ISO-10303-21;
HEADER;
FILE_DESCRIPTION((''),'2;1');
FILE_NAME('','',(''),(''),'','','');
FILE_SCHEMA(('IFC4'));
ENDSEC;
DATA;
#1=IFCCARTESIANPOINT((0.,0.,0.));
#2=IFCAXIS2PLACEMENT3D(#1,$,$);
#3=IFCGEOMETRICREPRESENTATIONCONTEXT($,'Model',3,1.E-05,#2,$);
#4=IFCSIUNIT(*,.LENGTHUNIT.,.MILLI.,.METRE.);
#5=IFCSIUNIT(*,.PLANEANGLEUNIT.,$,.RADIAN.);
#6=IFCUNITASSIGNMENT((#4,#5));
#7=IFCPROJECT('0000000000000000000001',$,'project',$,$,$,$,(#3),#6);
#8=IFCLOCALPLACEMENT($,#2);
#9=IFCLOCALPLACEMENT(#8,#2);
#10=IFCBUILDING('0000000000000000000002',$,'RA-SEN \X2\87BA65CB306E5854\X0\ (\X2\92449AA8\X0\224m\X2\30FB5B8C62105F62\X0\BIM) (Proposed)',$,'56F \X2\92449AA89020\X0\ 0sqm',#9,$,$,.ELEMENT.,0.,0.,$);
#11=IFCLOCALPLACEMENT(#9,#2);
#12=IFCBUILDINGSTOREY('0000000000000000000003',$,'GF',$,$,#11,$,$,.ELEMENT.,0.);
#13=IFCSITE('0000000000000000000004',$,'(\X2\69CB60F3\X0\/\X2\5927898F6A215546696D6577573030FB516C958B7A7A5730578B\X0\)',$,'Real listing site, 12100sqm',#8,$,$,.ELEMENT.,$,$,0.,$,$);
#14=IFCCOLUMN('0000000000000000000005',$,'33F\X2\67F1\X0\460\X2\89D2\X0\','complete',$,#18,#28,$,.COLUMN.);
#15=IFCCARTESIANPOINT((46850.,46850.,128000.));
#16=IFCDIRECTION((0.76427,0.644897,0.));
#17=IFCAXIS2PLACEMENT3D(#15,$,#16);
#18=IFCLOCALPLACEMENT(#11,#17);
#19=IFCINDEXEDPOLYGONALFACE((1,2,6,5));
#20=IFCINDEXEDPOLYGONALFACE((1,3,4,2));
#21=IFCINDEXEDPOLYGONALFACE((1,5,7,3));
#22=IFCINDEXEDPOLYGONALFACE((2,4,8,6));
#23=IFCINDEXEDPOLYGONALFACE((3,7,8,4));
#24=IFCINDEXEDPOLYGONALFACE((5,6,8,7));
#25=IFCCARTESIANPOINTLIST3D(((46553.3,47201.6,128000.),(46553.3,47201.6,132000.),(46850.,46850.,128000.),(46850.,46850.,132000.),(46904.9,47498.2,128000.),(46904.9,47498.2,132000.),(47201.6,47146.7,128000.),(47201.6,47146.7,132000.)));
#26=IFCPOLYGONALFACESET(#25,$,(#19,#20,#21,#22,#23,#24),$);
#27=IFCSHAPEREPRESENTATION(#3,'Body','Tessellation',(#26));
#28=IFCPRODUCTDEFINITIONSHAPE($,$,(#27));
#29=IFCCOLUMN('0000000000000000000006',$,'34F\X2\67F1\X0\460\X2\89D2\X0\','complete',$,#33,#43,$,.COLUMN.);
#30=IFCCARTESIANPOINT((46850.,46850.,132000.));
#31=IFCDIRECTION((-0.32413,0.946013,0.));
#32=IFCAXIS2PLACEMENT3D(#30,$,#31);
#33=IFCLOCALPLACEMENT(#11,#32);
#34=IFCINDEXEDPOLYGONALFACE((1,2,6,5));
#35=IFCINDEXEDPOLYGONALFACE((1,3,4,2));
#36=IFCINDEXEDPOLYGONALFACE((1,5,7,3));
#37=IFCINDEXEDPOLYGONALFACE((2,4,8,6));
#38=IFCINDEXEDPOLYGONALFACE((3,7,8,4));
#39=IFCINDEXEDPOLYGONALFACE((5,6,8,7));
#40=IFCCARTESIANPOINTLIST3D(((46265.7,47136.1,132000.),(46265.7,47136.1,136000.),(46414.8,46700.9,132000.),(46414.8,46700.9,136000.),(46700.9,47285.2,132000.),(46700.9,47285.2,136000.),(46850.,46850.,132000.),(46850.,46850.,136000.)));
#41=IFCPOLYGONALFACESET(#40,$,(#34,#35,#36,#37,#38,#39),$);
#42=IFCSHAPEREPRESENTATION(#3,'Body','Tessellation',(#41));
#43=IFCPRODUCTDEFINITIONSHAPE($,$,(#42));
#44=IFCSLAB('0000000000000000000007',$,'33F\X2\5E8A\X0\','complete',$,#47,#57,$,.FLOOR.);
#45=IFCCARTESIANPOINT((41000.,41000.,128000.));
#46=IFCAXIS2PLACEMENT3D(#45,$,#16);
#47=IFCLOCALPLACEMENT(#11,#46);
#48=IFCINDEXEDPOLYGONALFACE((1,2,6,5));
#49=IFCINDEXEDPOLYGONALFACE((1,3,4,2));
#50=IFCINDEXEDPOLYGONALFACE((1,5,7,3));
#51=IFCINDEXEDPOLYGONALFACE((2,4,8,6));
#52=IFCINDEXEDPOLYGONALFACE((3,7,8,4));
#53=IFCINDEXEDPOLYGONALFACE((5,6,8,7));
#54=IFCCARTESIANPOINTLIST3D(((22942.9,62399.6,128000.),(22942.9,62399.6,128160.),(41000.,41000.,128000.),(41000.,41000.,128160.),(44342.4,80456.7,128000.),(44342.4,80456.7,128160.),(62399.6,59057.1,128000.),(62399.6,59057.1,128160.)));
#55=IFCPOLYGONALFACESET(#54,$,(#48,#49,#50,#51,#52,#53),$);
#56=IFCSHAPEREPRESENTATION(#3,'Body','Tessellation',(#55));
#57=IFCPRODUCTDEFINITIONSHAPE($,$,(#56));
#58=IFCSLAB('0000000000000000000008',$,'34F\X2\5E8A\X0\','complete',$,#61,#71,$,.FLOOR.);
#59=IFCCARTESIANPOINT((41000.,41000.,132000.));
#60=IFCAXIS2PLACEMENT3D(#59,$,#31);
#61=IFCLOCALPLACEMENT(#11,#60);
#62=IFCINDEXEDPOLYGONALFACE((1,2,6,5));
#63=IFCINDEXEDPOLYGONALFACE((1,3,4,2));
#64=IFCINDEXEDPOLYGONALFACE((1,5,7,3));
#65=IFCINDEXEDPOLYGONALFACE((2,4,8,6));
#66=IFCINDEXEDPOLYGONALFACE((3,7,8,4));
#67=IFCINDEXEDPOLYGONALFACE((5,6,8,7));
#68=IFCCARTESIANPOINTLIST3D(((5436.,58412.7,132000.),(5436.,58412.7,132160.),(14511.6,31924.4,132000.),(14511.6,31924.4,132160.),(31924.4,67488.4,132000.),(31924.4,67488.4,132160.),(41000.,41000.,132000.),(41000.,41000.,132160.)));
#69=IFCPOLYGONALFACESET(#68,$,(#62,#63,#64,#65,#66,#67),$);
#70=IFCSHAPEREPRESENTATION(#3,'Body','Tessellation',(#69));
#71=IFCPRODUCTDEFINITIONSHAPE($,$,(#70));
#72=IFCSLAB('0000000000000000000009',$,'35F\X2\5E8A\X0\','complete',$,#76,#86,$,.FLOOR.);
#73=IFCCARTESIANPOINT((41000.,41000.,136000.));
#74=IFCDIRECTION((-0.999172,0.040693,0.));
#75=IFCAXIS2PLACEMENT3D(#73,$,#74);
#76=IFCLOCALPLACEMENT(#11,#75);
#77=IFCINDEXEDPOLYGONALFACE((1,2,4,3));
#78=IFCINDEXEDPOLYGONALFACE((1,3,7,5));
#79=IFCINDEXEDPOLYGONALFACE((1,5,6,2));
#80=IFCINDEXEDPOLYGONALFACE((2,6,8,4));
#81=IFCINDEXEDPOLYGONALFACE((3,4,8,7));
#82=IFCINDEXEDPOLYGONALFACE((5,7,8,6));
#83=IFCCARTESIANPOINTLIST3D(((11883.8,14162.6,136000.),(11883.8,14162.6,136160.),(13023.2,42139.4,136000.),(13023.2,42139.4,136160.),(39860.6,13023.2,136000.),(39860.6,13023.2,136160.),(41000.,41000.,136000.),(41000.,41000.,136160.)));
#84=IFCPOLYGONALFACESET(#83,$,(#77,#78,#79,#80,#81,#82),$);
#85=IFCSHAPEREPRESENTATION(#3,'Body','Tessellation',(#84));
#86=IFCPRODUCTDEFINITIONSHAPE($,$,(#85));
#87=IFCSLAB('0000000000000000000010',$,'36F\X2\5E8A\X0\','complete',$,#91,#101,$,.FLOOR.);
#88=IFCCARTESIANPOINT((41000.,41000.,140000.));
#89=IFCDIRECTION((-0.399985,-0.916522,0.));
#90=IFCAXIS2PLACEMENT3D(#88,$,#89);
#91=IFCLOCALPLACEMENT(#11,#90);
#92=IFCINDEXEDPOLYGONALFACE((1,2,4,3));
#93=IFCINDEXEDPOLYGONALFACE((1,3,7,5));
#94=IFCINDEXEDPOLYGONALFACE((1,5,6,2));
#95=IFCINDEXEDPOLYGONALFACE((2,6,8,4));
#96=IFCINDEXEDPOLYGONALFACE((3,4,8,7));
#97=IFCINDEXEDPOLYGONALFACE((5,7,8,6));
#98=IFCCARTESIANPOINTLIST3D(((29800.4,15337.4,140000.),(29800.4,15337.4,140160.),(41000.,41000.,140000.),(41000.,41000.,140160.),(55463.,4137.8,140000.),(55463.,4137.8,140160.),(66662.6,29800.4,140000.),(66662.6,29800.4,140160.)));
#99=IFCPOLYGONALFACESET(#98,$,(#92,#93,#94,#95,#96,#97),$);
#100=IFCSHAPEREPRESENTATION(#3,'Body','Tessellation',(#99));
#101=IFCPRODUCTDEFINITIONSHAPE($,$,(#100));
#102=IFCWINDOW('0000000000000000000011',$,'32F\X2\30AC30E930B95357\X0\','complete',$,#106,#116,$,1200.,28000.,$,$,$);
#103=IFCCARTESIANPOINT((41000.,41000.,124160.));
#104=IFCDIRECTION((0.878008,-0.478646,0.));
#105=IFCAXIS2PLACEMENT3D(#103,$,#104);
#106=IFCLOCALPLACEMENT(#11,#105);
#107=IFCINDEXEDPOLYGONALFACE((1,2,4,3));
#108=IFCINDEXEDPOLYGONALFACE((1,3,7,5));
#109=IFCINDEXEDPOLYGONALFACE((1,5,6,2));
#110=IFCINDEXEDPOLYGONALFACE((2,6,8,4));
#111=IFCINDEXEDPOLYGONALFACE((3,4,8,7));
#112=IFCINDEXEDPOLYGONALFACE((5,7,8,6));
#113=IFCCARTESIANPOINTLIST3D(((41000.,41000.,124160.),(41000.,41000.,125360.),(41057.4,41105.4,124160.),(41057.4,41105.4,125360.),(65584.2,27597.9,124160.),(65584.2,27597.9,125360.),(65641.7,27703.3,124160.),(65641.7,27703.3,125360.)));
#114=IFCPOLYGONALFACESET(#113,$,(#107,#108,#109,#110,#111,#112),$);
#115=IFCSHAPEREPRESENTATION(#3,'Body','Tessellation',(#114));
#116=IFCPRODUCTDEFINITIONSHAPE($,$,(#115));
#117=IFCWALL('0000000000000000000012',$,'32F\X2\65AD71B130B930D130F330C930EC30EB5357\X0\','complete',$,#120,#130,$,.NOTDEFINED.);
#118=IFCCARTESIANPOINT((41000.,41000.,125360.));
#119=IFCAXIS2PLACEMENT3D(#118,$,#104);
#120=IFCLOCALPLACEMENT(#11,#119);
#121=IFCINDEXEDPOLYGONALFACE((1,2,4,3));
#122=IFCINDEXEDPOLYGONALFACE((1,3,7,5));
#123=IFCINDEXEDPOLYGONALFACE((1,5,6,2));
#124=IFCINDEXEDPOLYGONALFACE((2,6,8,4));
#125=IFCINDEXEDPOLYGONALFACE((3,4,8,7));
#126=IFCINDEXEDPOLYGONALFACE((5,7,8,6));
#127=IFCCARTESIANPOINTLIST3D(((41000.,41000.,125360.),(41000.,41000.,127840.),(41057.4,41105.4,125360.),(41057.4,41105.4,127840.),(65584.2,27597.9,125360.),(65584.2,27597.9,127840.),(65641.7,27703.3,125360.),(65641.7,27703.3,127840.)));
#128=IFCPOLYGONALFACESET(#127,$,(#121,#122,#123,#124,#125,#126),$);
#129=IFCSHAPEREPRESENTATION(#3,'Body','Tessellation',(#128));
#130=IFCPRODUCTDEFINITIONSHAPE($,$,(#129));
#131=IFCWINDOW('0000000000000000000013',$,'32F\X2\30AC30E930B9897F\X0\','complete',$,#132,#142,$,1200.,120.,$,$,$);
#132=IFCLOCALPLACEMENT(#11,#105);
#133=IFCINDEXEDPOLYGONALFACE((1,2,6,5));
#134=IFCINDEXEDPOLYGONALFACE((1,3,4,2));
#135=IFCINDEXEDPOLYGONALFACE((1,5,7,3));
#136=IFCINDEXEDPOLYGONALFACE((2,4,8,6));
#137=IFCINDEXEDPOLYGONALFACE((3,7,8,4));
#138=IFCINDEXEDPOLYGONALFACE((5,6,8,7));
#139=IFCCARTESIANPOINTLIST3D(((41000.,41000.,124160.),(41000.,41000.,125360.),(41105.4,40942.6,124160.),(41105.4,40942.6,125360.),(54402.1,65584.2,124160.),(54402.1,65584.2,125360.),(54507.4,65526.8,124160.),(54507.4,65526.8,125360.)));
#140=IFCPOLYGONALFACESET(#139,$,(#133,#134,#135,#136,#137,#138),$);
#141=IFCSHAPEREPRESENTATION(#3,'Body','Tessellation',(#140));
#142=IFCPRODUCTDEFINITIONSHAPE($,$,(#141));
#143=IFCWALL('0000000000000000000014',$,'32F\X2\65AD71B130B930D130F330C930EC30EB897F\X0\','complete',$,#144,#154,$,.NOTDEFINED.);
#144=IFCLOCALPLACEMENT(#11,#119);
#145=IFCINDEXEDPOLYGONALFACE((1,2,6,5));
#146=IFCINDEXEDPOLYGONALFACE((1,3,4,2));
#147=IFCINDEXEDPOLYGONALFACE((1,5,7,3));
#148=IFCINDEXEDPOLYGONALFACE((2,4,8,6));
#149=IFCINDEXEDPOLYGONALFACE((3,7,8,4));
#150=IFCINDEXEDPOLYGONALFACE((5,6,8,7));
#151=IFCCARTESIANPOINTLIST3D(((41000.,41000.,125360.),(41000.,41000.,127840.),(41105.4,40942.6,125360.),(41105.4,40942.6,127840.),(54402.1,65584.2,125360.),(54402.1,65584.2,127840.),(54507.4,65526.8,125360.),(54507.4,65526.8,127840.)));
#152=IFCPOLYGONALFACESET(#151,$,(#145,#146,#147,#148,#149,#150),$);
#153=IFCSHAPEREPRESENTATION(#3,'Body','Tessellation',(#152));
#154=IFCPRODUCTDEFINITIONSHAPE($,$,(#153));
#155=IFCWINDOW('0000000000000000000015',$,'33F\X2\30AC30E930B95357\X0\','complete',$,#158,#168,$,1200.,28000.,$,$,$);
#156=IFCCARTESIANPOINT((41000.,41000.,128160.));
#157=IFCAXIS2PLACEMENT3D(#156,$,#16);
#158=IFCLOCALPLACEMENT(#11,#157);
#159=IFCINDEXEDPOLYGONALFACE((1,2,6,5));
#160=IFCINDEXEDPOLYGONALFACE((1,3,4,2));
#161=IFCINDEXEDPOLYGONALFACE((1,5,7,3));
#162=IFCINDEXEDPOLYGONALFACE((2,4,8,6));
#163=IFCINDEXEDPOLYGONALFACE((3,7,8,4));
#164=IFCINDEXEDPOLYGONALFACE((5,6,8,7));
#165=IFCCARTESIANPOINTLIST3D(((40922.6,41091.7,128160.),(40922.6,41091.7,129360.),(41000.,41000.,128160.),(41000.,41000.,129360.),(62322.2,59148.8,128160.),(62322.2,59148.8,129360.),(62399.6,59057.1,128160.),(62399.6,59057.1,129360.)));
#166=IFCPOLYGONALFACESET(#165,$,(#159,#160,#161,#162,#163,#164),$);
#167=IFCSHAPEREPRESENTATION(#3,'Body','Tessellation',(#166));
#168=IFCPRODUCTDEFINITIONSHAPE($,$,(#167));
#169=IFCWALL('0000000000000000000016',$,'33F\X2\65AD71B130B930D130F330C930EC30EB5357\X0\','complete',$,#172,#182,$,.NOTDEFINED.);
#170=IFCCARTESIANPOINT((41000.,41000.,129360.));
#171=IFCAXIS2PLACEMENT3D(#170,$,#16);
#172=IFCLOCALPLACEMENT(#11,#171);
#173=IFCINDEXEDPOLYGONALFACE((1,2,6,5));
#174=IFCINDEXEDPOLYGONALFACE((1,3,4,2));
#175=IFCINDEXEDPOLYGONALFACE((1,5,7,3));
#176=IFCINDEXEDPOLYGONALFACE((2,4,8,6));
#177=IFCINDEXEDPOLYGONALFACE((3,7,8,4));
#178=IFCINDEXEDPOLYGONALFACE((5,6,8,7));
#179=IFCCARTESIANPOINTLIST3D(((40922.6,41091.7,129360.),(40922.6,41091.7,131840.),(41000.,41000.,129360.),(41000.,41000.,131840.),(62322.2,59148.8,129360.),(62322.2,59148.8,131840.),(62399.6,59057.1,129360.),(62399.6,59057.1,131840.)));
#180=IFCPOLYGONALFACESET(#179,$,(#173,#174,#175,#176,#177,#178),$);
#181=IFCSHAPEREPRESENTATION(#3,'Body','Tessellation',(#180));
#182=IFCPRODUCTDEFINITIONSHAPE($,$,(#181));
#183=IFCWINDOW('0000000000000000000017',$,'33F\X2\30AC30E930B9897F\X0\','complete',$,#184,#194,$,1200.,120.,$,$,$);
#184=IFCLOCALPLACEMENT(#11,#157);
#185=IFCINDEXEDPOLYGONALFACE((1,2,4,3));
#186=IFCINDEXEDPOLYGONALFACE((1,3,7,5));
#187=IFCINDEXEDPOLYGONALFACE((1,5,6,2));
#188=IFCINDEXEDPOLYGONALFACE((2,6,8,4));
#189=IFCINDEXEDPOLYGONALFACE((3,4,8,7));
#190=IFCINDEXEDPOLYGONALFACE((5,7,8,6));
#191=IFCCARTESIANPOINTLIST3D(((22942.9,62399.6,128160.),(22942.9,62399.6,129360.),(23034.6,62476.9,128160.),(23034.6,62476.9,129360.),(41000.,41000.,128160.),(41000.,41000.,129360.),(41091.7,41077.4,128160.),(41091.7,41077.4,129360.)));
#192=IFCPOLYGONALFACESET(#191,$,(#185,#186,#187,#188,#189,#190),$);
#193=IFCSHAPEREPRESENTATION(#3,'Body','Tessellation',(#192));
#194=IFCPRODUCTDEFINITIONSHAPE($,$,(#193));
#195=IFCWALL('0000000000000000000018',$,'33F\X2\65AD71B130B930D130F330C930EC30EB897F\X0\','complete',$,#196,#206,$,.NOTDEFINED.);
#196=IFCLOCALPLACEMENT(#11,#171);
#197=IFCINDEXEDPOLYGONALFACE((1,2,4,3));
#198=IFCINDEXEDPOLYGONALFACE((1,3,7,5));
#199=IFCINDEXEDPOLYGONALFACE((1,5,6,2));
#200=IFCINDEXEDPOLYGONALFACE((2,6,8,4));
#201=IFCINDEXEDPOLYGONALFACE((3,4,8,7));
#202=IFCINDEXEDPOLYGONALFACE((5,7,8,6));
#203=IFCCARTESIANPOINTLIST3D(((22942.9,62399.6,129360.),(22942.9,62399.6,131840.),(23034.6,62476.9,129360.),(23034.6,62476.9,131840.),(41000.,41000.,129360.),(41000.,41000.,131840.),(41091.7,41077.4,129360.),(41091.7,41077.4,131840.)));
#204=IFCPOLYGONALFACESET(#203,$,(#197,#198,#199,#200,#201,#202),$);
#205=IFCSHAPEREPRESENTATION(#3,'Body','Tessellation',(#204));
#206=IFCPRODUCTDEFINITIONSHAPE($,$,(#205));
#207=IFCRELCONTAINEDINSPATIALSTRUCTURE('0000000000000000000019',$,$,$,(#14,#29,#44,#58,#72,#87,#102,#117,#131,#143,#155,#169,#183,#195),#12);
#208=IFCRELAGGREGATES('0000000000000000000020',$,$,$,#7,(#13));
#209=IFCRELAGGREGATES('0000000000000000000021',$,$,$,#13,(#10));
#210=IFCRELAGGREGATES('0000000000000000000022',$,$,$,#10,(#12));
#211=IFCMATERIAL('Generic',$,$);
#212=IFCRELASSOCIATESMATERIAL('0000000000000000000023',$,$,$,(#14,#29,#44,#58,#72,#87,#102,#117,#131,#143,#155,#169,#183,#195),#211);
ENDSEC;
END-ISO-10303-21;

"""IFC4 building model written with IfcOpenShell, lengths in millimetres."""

from ifc_helpers import new_model, si_unit, frame, frame_2d, origin, place, context, project, spatial, rectangle, extrude, material, element, save


model = new_model("IFC4")

# Units and contexts
model_context = context("Model", 3, precision=1e-05, world=origin())
ifc_project = project(units=[si_unit("LENGTHUNIT", "METRE", prefix="MILLI"), si_unit("PLANEANGLEUNIT", "RADIAN")], contexts=[model_context])

# Site, building, storey
site_placement = place(None, origin())
site = spatial("IfcSite", under=ifc_project, at=site_placement, Name="(構想/大規模商業敷地・公開空地型)", ObjectType="Real listing site, 12100sqm", CompositionType="ELEMENT", RefElevation=0.0)
building_placement = place(site_placement, origin())
building = spatial("IfcBuilding", under=site, at=building_placement, Name="RA-SEN 螺旋の塔 (鉄骨224m・完成形BIM) (Proposed)", ObjectType="56F 鉄骨造 0sqm", CompositionType="ELEMENT", ElevationOfRefHeight=0.0, ElevationOfTerrain=0.0)
storey_placement = place(building_placement, origin())
storey = spatial("IfcBuildingStorey", under=building, at=storey_placement, Name="GF", CompositionType="ELEMENT", Elevation=0.0)

# Columns
ifc_material = material(Name="Generic")
column_1_placement = place(storey_placement, frame((46850.0, 46850.0, 128000.0), x_axis=(0.76427, 0.644897, 0.0)))
element("IfcColumn", 1, at=column_1_placement, inside=storey, material=ifc_material, Name="33F柱460角", Description="complete", PredefinedType="COLUMN", context=model_context, shape_type="SweptSolid", body=[
    extrude(rectangle(XDim=460.0, YDim=460.0, at=frame_2d((230.0, 230.0))), frame((46850.0, 46850.0, 128000.0), x_axis=(0.76427, 0.644897, 0.0)), (0.0, 0.0, 1.0), 4000.0),
])
column_2_placement = place(storey_placement, frame((46850.0, 46850.0, 132000.0), x_axis=(-0.32413, 0.946013, 0.0)))
element("IfcColumn", 2, at=column_2_placement, inside=storey, material=ifc_material, Name="34F柱460角", Description="complete", PredefinedType="COLUMN", context=model_context, shape_type="SweptSolid", body=[
    extrude(rectangle(XDim=460.0, YDim=460.0, at=frame_2d((230.0, 230.0))), frame((46850.0, 46850.0, 132000.0), x_axis=(-0.32413, 0.946013, 0.0)), (0.0, 0.0, 1.0), 4000.0),
])

# Slabs
slab_1_placement = place(storey_placement, frame((41000.0, 41000.0, 128000.0), x_axis=(0.76427, 0.644897, 0.0)))
element("IfcSlab", 3, at=slab_1_placement, inside=storey, material=ifc_material, Name="33F床", Description="complete", PredefinedType="FLOOR", context=model_context, shape_type="SweptSolid", body=[
    extrude(rectangle(XDim=28000.0, YDim=28000.0, at=frame_2d((14000.0, 14000.0))), frame((41000.0, 41000.0, 128000.0), x_axis=(0.76427, 0.644897, 0.0)), (0.0, 0.0, 1.0), 160.0),
])
slab_2_placement = place(storey_placement, frame((41000.0, 41000.0, 132000.0), x_axis=(-0.32413, 0.946013, 0.0)))
element("IfcSlab", 4, at=slab_2_placement, inside=storey, material=ifc_material, Name="34F床", Description="complete", PredefinedType="FLOOR", context=model_context, shape_type="SweptSolid", body=[
    extrude(rectangle(XDim=28000.0, YDim=28000.0, at=frame_2d((14000.0, 14000.0))), frame((41000.0, 41000.0, 132000.0), x_axis=(-0.32413, 0.946013, 0.0)), (0.0, 0.0, 1.0), 160.0),
])
slab_3_placement = place(storey_placement, frame((41000.0, 41000.0, 136000.0), x_axis=(-0.999172, 0.040693, 0.0)))
element("IfcSlab", 5, at=slab_3_placement, inside=storey, material=ifc_material, Name="35F床", Description="complete", PredefinedType="FLOOR", context=model_context, shape_type="SweptSolid", body=[
    extrude(rectangle(XDim=28000.0, YDim=28000.0, at=frame_2d((14000.0, 14000.0))), frame((41000.0, 41000.0, 136000.0), x_axis=(-0.999172, 0.040693, 0.0)), (0.0, 0.0, 1.0), 160.0),
])
slab_4_placement = place(storey_placement, frame((41000.0, 41000.0, 140000.0), x_axis=(-0.399985, -0.916522, 0.0)))
element("IfcSlab", 6, at=slab_4_placement, inside=storey, material=ifc_material, Name="36F床", Description="complete", PredefinedType="FLOOR", context=model_context, shape_type="SweptSolid", body=[
    extrude(rectangle(XDim=28000.0, YDim=28000.0, at=frame_2d((14000.0, 14000.0))), frame((41000.0, 41000.0, 140000.0), x_axis=(-0.399985, -0.916522, 0.0)), (0.0, 0.0, 1.0), 160.0),
])

# Window
window_1_placement = place(storey_placement, frame((41000.0, 41000.0, 124160.0), x_axis=(0.878008, -0.478646, 0.0)))
element("IfcWindow", 7, at=window_1_placement, inside=storey, material=ifc_material, Name="32Fガラス南", Description="complete", OverallHeight=1200.0, OverallWidth=28000.0, context=model_context, shape_type="SweptSolid", body=[
    extrude(rectangle(XDim=28000.0, YDim=120.0, at=frame_2d((14000.0, 60.0))), frame((41000.0, 41000.0, 124160.0), x_axis=(0.878008, -0.478646, 0.0)), (0.0, 0.0, 1.0), 1200.0),
])

# Wall
wall_1_placement = place(storey_placement, frame((41000.0, 41000.0, 125360.0), x_axis=(0.878008, -0.478646, 0.0)))
element("IfcWall", 8, at=wall_1_placement, inside=storey, material=ifc_material, Name="32F断熱スパンドレル南", Description="complete", PredefinedType="NOTDEFINED", context=model_context, shape_type="SweptSolid", body=[
    extrude(rectangle(XDim=28000.0, YDim=120.0, at=frame_2d((14000.0, 60.0))), frame((41000.0, 41000.0, 125360.0), x_axis=(0.878008, -0.478646, 0.0)), (0.0, 0.0, 1.0), 2480.0),
])

# Window
window_2_placement = place(storey_placement, frame((41000.0, 41000.0, 124160.0), x_axis=(0.878008, -0.478646, 0.0)))
element("IfcWindow", 9, at=window_2_placement, inside=storey, material=ifc_material, Name="32Fガラス西", Description="complete", OverallHeight=1200.0, OverallWidth=120.0, context=model_context, shape_type="SweptSolid", body=[
    extrude(rectangle(XDim=120.0, YDim=28000.0, at=frame_2d((60.0, 14000.0))), frame((41000.0, 41000.0, 124160.0), x_axis=(0.878008, -0.478646, 0.0)), (0.0, 0.0, 1.0), 1200.0),
])

# Wall
wall_2_placement = place(storey_placement, frame((41000.0, 41000.0, 125360.0), x_axis=(0.878008, -0.478646, 0.0)))
element("IfcWall", 10, at=wall_2_placement, inside=storey, material=ifc_material, Name="32F断熱スパンドレル西", Description="complete", PredefinedType="NOTDEFINED", context=model_context, shape_type="SweptSolid", body=[
    extrude(rectangle(XDim=120.0, YDim=28000.0, at=frame_2d((60.0, 14000.0))), frame((41000.0, 41000.0, 125360.0), x_axis=(0.878008, -0.478646, 0.0)), (0.0, 0.0, 1.0), 2480.0),
])

# Window
window_3_placement = place(storey_placement, frame((41000.0, 41000.0, 128160.0), x_axis=(0.76427, 0.644897, 0.0)))
element("IfcWindow", 11, at=window_3_placement, inside=storey, material=ifc_material, Name="33Fガラス南", Description="complete", OverallHeight=1200.0, OverallWidth=28000.0, context=model_context, shape_type="SweptSolid", body=[
    extrude(rectangle(XDim=28000.0, YDim=120.0, at=frame_2d((14000.0, 60.0))), frame((41000.0, 41000.0, 128160.0), x_axis=(0.76427, 0.644897, 0.0)), (0.0, 0.0, 1.0), 1200.0),
])

# Wall
wall_3_placement = place(storey_placement, frame((41000.0, 41000.0, 129360.0), x_axis=(0.76427, 0.644897, 0.0)))
element("IfcWall", 12, at=wall_3_placement, inside=storey, material=ifc_material, Name="33F断熱スパンドレル南", Description="complete", PredefinedType="NOTDEFINED", context=model_context, shape_type="SweptSolid", body=[
    extrude(rectangle(XDim=28000.0, YDim=120.0, at=frame_2d((14000.0, 60.0))), frame((41000.0, 41000.0, 129360.0), x_axis=(0.76427, 0.644897, 0.0)), (0.0, 0.0, 1.0), 2480.0),
])

# Window
window_4_placement = place(storey_placement, frame((41000.0, 41000.0, 128160.0), x_axis=(0.76427, 0.644897, 0.0)))
element("IfcWindow", 13, at=window_4_placement, inside=storey, material=ifc_material, Name="33Fガラス西", Description="complete", OverallHeight=1200.0, OverallWidth=120.0, context=model_context, shape_type="SweptSolid", body=[
    extrude(rectangle(XDim=120.0, YDim=28000.0, at=frame_2d((60.0, 14000.0))), frame((41000.0, 41000.0, 128160.0), x_axis=(0.76427, 0.644897, 0.0)), (0.0, 0.0, 1.0), 1200.0),
])

# Wall
wall_4_placement = place(storey_placement, frame((41000.0, 41000.0, 129360.0), x_axis=(0.76427, 0.644897, 0.0)))
element("IfcWall", 14, at=wall_4_placement, inside=storey, material=ifc_material, Name="33F断熱スパンドレル西", Description="complete", PredefinedType="NOTDEFINED", context=model_context, shape_type="SweptSolid", body=[
    extrude(rectangle(XDim=120.0, YDim=28000.0, at=frame_2d((60.0, 14000.0))), frame((41000.0, 41000.0, 129360.0), x_axis=(0.76427, 0.644897, 0.0)), (0.0, 0.0, 1.0), 2480.0),
])

save(model, "model.ifc")
